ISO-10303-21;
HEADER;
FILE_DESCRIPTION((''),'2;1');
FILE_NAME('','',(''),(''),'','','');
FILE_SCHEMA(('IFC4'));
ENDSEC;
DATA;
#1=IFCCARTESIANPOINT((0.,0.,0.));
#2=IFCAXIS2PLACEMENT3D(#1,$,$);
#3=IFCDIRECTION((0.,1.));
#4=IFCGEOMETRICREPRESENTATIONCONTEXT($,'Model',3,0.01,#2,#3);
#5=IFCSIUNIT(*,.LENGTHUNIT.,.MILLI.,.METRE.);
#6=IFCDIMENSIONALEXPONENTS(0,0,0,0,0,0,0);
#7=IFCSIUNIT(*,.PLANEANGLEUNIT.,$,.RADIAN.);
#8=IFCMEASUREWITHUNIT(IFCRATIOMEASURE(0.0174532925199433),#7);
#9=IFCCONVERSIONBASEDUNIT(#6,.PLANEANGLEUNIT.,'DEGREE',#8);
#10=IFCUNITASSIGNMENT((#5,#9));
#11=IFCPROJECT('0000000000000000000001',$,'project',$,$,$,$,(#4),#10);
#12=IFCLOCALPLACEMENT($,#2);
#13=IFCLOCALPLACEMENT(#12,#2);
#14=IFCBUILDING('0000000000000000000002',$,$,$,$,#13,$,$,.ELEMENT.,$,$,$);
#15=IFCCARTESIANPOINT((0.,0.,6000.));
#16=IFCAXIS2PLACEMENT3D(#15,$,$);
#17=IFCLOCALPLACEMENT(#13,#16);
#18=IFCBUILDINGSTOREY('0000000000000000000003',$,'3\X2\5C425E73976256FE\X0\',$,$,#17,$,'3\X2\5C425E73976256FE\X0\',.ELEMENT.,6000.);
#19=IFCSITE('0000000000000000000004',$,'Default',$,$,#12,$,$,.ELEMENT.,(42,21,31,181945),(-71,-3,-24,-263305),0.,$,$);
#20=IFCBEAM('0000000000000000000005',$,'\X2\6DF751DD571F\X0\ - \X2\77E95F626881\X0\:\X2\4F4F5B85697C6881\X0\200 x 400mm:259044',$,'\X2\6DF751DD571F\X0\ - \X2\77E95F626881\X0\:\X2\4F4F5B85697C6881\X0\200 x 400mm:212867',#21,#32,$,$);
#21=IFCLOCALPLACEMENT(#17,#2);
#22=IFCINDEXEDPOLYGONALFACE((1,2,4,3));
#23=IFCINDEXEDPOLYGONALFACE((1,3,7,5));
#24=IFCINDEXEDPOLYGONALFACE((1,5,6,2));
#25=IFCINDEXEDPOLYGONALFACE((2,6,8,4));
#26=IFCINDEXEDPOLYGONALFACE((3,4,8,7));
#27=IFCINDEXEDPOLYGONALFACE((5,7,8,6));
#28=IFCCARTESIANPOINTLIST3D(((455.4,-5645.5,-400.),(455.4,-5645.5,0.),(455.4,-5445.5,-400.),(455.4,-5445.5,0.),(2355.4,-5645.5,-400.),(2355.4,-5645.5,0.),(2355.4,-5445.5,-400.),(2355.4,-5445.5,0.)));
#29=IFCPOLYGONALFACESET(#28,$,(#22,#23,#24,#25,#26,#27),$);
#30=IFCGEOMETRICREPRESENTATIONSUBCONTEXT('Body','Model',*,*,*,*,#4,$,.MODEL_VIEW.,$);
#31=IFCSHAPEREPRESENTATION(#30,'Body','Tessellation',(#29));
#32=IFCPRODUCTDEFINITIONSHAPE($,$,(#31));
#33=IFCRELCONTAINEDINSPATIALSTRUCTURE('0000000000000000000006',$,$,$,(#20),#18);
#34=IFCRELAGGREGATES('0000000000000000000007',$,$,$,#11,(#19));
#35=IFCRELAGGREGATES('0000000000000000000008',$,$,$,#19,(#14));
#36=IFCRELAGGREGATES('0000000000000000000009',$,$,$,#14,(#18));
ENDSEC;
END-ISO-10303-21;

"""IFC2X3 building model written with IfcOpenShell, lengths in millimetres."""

from ifc_helpers import new_model, entity, si_unit, converted_unit, direction, frame, frame_2d, origin, place, context, subcontext, project, spatial, rectangle, extrude, element, save


model = new_model("IFC2X3")

# Units and contexts
model_context = context("Model", 3, precision=0.01, world=origin(), true_north=direction((0.0, 1.0)))
body_context = subcontext(model_context, "Body", "Model", "MODEL_VIEW")
ifc_project = project(units=[si_unit("LENGTHUNIT", "METRE", prefix="MILLI"), converted_unit("PLANEANGLEUNIT", "DEGREE", entity("IfcRatioMeasure", 0.0174532925199433), si_unit("PLANEANGLEUNIT", "RADIAN"), dimensions=[0, 0, 0, 0, 0, 0, 0])], contexts=[model_context])

# Site, building, storey
site_placement = place(None, origin())
site = spatial("IfcSite", under=ifc_project, at=site_placement, Name="Default", CompositionType="ELEMENT", RefLatitude=(42, 21, 31, 181945), RefLongitude=(-71, -3, -24, -263305), RefElevation=0.0)
building_placement = place(site_placement, origin())
building = spatial("IfcBuilding", under=site, at=building_placement, CompositionType="ELEMENT")
storey_placement = place(building_placement, frame((0.0, 0.0, 6000.0)))
storey = spatial("IfcBuildingStorey", under=building, at=storey_placement, Name="3层平面图", LongName="3层平面图", CompositionType="ELEMENT", Elevation=6000.0)

# Beam
beam_placement = place(storey_placement, frame((2455.4, -5545.5, 0.0), z_axis=(0.0, 0.0, 1.0), x_axis=(-1.0, 0.0, 0.0)))
element("IfcBeam", 1, at=beam_placement, inside=storey, Name="混凝土 - 矩形梁:住宅楼梁200 x 400mm:259044", ObjectType="混凝土 - 矩形梁:住宅楼梁200 x 400mm:212867", context=body_context, shape_type="SweptSolid", body=[
    extrude(rectangle(XDim=400.0, YDim=200.0, at=frame_2d((0.0, 0.0), x_axis=(1.0, 0.0))), frame((100.0, 0.0, -200.0), z_axis=(1.0, 0.0, 0.0), x_axis=(0.0, 0.0, -1.0)), (0.0, 0.0, 1.0), 1900.0),
])

save(model, "model.ifc")
